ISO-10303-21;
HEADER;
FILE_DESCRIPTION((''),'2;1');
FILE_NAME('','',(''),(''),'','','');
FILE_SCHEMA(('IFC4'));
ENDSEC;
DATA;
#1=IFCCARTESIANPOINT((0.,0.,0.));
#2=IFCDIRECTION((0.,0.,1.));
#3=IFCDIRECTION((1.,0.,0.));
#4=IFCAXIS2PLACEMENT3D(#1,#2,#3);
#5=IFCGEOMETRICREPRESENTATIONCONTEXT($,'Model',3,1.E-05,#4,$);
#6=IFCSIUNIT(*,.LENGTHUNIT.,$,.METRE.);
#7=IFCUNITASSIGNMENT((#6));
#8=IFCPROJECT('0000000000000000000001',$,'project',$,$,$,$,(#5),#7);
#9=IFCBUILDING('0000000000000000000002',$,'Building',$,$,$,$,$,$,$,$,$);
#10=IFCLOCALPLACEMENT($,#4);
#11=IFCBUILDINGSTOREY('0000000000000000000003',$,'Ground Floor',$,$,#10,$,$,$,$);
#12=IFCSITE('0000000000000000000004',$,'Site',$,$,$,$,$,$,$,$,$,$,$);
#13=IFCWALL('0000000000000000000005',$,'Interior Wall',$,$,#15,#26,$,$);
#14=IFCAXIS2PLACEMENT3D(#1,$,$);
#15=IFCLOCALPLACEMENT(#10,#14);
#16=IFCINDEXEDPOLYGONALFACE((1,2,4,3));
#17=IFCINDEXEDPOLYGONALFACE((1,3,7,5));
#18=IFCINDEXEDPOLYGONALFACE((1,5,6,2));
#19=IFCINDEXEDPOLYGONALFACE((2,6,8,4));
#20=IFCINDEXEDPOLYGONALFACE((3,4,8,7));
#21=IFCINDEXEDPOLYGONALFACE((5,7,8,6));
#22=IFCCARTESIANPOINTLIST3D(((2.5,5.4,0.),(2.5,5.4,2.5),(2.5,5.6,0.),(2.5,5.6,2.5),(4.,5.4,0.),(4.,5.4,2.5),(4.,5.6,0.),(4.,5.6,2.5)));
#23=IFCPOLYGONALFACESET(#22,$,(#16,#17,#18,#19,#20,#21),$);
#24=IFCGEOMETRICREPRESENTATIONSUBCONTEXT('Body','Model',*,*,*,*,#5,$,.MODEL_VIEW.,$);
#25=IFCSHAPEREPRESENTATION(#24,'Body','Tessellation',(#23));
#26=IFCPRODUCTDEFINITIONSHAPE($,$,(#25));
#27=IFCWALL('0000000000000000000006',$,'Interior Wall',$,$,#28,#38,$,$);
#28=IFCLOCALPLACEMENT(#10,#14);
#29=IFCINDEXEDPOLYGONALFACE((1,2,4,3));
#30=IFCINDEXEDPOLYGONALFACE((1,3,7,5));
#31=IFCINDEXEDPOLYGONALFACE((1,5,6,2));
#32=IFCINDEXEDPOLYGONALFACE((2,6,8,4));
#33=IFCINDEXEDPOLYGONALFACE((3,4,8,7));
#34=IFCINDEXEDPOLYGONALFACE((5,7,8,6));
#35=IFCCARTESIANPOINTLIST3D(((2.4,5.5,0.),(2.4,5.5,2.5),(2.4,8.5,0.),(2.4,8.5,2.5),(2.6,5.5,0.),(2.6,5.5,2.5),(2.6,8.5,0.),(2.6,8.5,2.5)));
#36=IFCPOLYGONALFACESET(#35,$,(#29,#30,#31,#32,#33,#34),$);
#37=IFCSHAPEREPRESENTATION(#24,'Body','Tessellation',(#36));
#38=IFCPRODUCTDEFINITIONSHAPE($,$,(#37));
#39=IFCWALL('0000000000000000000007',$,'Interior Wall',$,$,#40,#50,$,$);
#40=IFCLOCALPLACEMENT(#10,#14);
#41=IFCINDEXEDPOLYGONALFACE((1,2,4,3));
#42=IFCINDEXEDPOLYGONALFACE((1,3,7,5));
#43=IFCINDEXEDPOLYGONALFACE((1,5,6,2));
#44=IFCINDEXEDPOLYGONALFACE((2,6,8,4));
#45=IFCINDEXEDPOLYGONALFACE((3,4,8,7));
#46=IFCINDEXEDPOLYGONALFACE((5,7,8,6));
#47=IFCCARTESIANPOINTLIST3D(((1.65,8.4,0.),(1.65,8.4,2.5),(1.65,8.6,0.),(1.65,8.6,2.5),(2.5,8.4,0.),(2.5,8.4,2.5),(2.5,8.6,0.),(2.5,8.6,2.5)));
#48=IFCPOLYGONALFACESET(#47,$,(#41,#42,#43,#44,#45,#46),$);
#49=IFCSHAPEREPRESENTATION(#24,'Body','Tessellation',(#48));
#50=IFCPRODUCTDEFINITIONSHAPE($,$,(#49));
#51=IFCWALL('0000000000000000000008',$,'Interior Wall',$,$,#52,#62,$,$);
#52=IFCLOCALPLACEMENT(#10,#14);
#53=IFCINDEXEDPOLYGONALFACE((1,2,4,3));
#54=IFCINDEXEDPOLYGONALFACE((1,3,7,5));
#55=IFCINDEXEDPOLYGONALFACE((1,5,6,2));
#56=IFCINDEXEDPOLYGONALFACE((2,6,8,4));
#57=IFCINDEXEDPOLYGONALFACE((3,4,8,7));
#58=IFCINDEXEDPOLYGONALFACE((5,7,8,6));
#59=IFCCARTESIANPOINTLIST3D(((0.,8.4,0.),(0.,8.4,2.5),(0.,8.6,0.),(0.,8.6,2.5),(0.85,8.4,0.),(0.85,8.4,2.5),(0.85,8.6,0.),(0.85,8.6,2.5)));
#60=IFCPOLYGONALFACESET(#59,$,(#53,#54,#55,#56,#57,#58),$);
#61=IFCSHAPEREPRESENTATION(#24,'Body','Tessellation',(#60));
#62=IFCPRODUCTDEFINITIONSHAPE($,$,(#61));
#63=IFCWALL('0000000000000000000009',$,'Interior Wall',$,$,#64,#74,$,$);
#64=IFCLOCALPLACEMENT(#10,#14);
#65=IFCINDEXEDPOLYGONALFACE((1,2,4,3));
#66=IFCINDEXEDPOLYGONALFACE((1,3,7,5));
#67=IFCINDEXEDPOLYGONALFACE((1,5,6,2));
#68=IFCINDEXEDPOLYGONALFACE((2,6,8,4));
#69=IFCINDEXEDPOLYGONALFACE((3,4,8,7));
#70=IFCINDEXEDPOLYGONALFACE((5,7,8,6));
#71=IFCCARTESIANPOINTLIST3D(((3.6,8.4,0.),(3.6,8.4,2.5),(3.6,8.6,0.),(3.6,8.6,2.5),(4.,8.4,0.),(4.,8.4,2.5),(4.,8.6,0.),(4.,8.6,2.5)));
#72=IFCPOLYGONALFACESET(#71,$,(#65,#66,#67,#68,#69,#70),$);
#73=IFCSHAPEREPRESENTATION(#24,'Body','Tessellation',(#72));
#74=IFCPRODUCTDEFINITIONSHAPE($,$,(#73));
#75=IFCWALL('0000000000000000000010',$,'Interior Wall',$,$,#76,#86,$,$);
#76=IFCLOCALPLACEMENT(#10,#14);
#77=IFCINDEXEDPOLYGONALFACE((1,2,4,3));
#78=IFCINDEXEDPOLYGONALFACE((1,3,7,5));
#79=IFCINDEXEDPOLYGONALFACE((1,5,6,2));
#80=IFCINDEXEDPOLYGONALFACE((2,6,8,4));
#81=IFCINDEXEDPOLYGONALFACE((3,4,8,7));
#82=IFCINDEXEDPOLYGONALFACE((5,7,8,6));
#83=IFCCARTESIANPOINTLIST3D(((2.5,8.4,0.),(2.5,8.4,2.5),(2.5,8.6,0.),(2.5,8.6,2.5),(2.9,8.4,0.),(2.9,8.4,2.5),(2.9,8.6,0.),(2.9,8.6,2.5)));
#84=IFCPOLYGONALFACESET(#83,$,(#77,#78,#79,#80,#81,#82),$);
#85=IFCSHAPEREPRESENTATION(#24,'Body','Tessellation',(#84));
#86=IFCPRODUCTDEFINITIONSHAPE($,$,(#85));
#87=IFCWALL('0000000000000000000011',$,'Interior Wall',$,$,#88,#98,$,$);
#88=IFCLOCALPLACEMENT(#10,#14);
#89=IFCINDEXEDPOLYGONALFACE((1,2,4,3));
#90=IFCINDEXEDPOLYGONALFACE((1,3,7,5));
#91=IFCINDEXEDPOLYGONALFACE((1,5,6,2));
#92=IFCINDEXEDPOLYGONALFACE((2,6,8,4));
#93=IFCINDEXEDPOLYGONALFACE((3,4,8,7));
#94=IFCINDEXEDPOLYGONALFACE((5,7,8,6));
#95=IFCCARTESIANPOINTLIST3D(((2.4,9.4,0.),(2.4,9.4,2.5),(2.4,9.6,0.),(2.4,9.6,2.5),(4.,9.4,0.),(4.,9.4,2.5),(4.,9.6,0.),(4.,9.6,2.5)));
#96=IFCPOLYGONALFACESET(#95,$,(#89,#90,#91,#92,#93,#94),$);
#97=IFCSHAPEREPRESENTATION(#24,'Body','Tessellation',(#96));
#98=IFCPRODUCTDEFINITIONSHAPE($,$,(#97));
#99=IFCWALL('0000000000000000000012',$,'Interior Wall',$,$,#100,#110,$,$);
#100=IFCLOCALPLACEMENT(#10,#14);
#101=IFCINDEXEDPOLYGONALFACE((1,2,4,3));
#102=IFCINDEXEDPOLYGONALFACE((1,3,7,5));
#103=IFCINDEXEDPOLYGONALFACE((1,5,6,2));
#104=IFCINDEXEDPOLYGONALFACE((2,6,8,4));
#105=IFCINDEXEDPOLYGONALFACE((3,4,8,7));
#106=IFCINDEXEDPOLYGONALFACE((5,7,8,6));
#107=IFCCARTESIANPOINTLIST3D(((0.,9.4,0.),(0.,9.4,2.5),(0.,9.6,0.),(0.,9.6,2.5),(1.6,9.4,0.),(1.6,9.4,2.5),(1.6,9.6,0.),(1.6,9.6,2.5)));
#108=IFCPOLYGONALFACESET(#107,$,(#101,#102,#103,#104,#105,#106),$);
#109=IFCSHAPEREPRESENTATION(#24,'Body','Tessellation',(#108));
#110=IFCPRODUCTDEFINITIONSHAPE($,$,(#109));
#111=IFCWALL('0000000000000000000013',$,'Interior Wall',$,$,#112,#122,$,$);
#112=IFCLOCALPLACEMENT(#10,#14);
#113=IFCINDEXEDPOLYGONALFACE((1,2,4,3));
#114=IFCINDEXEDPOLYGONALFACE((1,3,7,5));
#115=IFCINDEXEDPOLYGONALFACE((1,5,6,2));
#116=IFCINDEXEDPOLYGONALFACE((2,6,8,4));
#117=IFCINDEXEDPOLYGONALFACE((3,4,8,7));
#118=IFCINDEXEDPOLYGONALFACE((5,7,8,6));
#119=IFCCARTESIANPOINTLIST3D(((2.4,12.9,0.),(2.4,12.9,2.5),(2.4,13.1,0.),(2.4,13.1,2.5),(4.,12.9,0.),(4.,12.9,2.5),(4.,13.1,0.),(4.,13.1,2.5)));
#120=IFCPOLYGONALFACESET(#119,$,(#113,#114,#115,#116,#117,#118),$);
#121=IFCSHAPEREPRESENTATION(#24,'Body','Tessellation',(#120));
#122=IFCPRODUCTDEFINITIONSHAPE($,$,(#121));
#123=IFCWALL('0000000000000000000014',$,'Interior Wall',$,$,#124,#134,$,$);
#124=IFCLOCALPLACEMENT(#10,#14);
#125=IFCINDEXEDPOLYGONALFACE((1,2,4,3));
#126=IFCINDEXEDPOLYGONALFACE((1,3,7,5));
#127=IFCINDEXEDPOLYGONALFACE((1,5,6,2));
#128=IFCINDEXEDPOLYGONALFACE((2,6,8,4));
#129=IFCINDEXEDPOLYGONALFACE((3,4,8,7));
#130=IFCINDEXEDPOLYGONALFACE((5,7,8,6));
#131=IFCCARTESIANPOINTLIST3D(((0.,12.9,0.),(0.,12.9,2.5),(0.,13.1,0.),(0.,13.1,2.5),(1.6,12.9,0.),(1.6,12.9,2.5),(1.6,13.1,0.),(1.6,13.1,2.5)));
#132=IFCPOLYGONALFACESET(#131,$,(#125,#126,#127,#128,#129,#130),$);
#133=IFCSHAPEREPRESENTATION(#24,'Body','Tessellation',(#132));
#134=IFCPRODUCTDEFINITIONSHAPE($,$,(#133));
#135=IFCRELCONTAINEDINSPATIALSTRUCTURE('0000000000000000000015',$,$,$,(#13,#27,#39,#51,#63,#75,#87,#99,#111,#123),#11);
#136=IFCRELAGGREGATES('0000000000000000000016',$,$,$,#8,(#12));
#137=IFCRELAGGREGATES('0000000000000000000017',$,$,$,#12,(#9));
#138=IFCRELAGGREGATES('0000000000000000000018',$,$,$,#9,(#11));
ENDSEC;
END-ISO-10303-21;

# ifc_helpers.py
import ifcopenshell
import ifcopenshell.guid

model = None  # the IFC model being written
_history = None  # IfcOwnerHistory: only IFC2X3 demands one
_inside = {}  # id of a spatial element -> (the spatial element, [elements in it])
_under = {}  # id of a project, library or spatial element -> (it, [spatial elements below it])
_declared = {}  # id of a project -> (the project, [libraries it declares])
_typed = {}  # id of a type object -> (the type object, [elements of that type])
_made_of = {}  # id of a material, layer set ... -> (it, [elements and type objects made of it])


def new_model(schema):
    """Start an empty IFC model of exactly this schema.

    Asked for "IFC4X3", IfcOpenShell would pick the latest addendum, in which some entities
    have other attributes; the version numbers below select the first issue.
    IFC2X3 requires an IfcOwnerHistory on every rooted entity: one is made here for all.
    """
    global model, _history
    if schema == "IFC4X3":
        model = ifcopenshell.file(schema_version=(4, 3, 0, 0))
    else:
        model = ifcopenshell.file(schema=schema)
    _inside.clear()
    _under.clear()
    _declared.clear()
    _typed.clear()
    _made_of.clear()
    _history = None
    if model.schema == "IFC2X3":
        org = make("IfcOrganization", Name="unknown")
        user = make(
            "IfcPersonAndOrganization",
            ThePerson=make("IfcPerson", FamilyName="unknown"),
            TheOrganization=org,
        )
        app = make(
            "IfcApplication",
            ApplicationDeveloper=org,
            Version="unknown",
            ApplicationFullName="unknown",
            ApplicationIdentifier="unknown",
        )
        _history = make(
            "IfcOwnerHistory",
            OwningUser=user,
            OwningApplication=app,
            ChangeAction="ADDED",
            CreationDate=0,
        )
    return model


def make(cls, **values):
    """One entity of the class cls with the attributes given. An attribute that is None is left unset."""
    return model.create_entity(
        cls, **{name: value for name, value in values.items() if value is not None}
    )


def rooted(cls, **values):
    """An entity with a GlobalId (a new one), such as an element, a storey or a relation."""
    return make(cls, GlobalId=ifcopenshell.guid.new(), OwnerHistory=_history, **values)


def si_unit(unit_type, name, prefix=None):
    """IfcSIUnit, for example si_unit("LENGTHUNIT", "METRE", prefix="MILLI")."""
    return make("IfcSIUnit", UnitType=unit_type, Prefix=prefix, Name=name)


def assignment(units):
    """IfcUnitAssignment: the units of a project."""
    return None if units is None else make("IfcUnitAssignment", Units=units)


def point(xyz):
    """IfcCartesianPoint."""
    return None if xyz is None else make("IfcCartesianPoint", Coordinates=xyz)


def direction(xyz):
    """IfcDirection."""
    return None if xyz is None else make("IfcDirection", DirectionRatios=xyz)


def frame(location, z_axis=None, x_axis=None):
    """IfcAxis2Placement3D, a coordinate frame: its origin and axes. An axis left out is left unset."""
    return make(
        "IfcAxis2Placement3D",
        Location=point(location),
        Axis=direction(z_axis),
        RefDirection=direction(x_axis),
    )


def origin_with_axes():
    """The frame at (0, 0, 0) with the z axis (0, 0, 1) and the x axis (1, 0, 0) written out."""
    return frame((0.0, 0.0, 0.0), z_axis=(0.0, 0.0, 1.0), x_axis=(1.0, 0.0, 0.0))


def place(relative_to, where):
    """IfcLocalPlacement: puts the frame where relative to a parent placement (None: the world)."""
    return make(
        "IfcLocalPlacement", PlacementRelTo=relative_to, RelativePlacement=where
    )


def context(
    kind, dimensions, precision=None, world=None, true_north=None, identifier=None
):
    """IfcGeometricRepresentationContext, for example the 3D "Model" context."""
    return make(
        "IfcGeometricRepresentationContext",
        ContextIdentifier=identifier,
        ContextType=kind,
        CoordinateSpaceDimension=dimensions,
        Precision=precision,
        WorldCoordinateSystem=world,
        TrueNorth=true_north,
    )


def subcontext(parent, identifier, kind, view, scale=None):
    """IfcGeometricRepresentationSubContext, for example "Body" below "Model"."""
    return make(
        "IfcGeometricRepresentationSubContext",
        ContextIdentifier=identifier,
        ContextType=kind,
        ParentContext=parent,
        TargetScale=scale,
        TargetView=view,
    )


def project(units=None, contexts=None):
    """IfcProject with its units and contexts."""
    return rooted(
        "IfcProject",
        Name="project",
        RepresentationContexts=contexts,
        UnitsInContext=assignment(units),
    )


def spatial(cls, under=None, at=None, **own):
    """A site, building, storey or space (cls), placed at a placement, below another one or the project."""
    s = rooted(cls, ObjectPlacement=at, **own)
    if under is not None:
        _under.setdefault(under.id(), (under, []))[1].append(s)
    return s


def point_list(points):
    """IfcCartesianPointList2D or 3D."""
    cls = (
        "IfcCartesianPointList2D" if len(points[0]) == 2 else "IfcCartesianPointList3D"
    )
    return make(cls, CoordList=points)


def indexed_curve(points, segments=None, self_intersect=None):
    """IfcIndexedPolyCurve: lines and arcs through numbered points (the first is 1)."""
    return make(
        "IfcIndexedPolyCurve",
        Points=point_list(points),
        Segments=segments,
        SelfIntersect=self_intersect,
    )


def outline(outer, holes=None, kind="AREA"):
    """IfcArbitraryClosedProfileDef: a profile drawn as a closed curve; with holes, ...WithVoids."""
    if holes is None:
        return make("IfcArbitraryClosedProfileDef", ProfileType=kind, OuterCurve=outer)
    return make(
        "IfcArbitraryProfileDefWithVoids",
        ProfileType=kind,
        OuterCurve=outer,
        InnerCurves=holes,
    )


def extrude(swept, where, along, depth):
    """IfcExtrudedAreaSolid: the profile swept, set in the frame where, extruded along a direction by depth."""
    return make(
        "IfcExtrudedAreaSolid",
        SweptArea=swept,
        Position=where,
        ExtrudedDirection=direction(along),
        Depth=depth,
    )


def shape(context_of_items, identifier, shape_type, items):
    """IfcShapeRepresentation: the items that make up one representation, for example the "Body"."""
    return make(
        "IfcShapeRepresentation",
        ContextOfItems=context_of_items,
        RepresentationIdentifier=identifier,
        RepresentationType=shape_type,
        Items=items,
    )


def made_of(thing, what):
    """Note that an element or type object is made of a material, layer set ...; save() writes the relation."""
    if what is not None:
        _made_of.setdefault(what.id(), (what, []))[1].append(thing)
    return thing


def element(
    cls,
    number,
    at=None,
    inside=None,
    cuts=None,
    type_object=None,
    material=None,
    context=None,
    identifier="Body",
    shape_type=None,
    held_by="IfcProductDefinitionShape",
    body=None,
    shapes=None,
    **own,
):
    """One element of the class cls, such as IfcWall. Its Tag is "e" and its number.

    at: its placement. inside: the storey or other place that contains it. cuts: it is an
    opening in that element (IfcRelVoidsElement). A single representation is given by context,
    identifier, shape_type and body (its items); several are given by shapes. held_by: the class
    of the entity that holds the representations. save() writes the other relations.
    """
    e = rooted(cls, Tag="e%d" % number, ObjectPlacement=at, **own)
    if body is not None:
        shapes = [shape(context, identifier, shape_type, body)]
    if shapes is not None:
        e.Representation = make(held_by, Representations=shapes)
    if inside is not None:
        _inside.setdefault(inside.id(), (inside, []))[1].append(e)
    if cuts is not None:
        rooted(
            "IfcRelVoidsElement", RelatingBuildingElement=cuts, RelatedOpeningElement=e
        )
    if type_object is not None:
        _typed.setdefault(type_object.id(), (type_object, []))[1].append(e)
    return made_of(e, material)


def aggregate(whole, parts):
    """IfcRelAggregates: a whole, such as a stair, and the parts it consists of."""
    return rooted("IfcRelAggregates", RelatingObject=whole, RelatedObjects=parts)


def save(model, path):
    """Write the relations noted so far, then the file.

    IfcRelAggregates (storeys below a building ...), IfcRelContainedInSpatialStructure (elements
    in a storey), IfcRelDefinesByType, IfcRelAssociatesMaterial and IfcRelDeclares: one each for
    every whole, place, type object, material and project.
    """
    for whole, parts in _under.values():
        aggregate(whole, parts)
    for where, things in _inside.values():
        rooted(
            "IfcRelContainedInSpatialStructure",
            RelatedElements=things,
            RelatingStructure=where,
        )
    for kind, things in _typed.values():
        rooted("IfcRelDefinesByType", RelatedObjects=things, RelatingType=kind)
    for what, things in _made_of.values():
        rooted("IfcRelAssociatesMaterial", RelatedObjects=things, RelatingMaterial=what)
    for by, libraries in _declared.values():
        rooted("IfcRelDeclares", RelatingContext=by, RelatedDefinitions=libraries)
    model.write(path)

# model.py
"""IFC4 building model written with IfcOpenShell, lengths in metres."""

from ifc_helpers import new_model, si_unit, frame, origin_with_axes, place, context, subcontext, project, spatial, indexed_curve, outline, extrude, element, save


model = new_model("IFC4")

# Units and contexts
model_context = context("Model", 3, precision=1e-05, world=origin_with_axes())
body_context = subcontext(model_context, "Body", "Model", "MODEL_VIEW")
ifc_project = project(units=[si_unit("LENGTHUNIT", "METRE")], contexts=[model_context])

# Site, building, storey
site = spatial("IfcSite", under=ifc_project, Name="Site")
building = spatial("IfcBuilding", under=site, Name="Building")
storey_placement = place(None, origin_with_axes())
storey = spatial("IfcBuildingStorey", under=building, at=storey_placement, Name="Ground Floor")

# Walls
wall_1_placement = place(storey_placement, frame((4.0, 5.5, 0.0), z_axis=(0.0, 0.0, 1.0), x_axis=(-1.0, 0.0, 0.0)))
element("IfcWall", 1, at=wall_1_placement, inside=storey, Name="Interior Wall", context=body_context, shape_type="SweptSolid", body=[
    extrude(outline(indexed_curve([(0.0, 0.0), (0.0, 0.2), (1.5, 0.2), (1.5, 0.0), (0.0, 0.0)], self_intersect=False)), frame((0.0, -0.1, 0.0), z_axis=(0.0, 0.0, 1.0), x_axis=(1.0, 0.0, 0.0)), (0.0, 0.0, 1.0), 2.5),
])
wall_2_placement = place(storey_placement, frame((2.5, 5.5, 0.0), z_axis=(0.0, 0.0, 1.0), x_axis=(0.0, 1.0, 0.0)))
element("IfcWall", 2, at=wall_2_placement, inside=storey, Name="Interior Wall", context=body_context, shape_type="SweptSolid", body=[
    extrude(outline(indexed_curve([(0.0, 0.0), (0.0, 0.2), (3.0, 0.2), (3.0, 0.0), (0.0, 0.0)], self_intersect=False)), frame((0.0, -0.1, 0.0), z_axis=(0.0, 0.0, 1.0), x_axis=(1.0, 0.0, 0.0)), (0.0, 0.0, 1.0), 2.5),
])
for number, where, z_axis, x_axis, name in (
    (3, (2.5, 8.5, 0.0), (0.0, 0.0, 1.0), (-1.0, 0.0, 0.0), "Interior Wall"),
    (4, (0.85, 8.5, 0.0), (0.0, 0.0, 1.0), (-1.0, 0.0, 0.0), "Interior Wall"),
):
    element("IfcWall", number, at=place(storey_placement, frame(where, z_axis=z_axis, x_axis=x_axis)), inside=storey, Name=name, context=body_context, shape_type="SweptSolid", body=[
        extrude(outline(indexed_curve([(0.0, 0.0), (0.0, 0.2), (0.85, 0.2), (0.85, 0.0), (0.0, 0.0)], self_intersect=False)), frame((0.0, -0.1, 0.0), z_axis=(0.0, 0.0, 1.0), x_axis=(1.0, 0.0, 0.0)), (0.0, 0.0, 1.0), 2.5),
    ])
for number, where, z_axis, x_axis, name in (
    (5, (4.0, 8.5, 0.0), (0.0, 0.0, 1.0), (-1.0, 0.0, 0.0), "Interior Wall"),
    (6, (2.9, 8.5, 0.0), (0.0, 0.0, 1.0), (-1.0, 0.0, 0.0), "Interior Wall"),
):
    element("IfcWall", number, at=place(storey_placement, frame(where, z_axis=z_axis, x_axis=x_axis)), inside=storey, Name=name, context=body_context, shape_type="SweptSolid", body=[
        extrude(outline(indexed_curve([(0.0, 0.0), (0.0, 0.2), (0.4, 0.2), (0.4, 0.0), (0.0, 0.0)], self_intersect=False)), frame((0.0, -0.1, 0.0), z_axis=(0.0, 0.0, 1.0), x_axis=(1.0, 0.0, 0.0)), (0.0, 0.0, 1.0), 2.5),
    ])
for number, where, z_axis, x_axis, name in (
    (7, (4.0, 9.5, 0.0), (0.0, 0.0, 1.0), (-1.0, 0.0, 0.0), "Interior Wall"),
    (8, (1.6, 9.5, 0.0), (0.0, 0.0, 1.0), (-1.0, 0.0, 0.0), "Interior Wall"),
    (9, (4.0, 13.0, 0.0), (0.0, 0.0, 1.0), (-1.0, 0.0, 0.0), "Interior Wall"),
    (10, (1.6, 13.0, 0.0), (0.0, 0.0, 1.0), (-1.0, 0.0, 0.0), "Interior Wall"),
):
    element("IfcWall", number, at=place(storey_placement, frame(where, z_axis=z_axis, x_axis=x_axis)), inside=storey, Name=name, context=body_context, shape_type="SweptSolid", body=[
        extrude(outline(indexed_curve([(0.0, 0.0), (0.0, 0.2), (1.6, 0.2), (1.6, 0.0), (0.0, 0.0)], self_intersect=False)), frame((0.0, -0.1, 0.0), z_axis=(0.0, 0.0, 1.0), x_axis=(1.0, 0.0, 0.0)), (0.0, 0.0, 1.0), 2.5),
    ])

save(model, "model.ifc")
